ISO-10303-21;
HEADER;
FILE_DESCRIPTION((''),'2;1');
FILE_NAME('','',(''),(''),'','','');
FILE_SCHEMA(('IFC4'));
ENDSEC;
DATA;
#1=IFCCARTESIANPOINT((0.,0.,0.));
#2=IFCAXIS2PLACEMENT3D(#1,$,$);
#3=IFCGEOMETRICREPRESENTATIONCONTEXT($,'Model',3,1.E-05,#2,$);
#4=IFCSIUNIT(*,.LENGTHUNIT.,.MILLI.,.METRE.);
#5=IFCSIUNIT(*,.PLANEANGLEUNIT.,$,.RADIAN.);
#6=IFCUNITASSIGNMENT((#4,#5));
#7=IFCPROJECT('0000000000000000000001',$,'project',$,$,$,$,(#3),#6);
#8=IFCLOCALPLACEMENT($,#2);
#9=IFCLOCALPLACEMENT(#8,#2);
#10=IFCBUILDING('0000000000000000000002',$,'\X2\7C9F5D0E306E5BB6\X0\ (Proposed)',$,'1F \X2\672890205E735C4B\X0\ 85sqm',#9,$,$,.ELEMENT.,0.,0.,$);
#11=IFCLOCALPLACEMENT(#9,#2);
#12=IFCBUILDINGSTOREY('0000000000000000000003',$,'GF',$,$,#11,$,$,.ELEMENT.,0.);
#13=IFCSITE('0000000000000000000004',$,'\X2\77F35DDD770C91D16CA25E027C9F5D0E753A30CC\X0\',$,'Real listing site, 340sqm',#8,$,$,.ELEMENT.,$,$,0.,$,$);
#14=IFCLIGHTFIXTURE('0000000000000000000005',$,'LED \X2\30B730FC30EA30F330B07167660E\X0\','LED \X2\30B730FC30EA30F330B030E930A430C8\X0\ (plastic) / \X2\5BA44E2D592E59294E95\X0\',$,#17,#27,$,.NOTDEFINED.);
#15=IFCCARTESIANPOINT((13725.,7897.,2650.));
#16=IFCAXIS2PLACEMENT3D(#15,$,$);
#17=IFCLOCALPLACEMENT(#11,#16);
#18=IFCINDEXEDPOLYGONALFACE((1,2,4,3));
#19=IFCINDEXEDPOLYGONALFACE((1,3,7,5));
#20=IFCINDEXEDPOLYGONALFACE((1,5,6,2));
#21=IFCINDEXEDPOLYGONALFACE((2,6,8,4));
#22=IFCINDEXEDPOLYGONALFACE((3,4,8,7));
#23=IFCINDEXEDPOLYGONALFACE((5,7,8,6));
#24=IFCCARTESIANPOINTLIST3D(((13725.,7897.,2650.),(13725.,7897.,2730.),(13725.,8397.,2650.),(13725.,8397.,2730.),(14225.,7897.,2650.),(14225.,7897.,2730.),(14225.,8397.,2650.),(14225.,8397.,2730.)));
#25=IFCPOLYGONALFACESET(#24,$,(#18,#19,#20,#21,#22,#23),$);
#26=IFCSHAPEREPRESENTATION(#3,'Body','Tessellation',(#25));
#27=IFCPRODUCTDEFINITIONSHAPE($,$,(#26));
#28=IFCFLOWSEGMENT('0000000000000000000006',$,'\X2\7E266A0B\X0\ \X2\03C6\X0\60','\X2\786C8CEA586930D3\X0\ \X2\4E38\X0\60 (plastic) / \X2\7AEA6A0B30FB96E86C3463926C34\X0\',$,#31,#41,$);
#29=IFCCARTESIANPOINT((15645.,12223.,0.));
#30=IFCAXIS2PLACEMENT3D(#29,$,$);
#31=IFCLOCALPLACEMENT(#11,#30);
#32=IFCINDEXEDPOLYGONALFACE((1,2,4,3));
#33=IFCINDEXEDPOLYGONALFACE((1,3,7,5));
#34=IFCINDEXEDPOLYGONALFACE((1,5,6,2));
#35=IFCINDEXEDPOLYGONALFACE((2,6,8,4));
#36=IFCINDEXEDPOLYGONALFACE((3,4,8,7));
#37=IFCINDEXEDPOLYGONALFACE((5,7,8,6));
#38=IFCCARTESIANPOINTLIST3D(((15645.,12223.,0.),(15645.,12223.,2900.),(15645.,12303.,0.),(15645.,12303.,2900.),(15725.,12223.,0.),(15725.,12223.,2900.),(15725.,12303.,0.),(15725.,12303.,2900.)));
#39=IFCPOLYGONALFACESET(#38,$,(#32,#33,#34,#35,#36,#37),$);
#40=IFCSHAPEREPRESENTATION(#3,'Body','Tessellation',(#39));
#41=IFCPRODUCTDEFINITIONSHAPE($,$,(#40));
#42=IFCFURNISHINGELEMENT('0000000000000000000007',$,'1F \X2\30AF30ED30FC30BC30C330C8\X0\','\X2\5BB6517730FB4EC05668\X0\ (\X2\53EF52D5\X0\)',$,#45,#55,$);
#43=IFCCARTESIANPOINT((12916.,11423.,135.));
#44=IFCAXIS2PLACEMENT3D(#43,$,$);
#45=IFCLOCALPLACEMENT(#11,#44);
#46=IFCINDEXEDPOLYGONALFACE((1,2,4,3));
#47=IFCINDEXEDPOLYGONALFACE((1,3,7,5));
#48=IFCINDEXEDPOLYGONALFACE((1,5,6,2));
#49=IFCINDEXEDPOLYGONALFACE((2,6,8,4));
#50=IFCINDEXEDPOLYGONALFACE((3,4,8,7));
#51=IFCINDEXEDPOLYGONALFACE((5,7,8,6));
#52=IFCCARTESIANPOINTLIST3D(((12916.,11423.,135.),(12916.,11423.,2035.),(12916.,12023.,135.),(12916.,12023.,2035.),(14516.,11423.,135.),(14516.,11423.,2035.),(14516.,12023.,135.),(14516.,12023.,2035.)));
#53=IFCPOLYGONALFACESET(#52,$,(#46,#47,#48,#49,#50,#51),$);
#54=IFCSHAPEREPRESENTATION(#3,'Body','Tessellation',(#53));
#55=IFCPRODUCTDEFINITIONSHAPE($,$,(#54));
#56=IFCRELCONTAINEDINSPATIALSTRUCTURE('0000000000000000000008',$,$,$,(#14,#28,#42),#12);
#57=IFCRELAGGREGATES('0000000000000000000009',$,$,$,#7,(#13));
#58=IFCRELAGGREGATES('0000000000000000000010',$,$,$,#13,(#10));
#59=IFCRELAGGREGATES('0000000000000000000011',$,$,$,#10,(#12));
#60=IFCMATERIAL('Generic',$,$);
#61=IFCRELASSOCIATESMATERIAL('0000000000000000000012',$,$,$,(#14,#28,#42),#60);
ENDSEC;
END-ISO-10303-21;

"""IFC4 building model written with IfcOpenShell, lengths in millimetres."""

from ifc_helpers import new_model, si_unit, frame, frame_2d, origin, place, context, project, spatial, rectangle, extrude, material, element, save


model = new_model("IFC4")

# Units and contexts
model_context = context("Model", 3, precision=1e-05, world=origin())
ifc_project = project(units=[si_unit("LENGTHUNIT", "METRE", prefix="MILLI"), si_unit("PLANEANGLEUNIT", "RADIAN")], contexts=[model_context])

# Site, building, storey
site_placement = place(None, origin())
site = spatial("IfcSite", under=ifc_project, at=site_placement, Name="石川県金沢市粟崎町ヌ", ObjectType="Real listing site, 340sqm", CompositionType="ELEMENT", RefElevation=0.0)
building_placement = place(site_placement, origin())
building = spatial("IfcBuilding", under=site, at=building_placement, Name="粟崎の家 (Proposed)", ObjectType="1F 木造平屋 85sqm", CompositionType="ELEMENT", ElevationOfRefHeight=0.0, ElevationOfTerrain=0.0)
storey_placement = place(building_placement, origin())
storey = spatial("IfcBuildingStorey", under=building, at=storey_placement, Name="GF", CompositionType="ELEMENT", Elevation=0.0)

# Shared definitions
ifc_material_1 = material(Name="Generic")

# Light fixture
light_fixture_1_placement = place(storey_placement, frame((13725.0, 7897.0, 2650.0)))
element("IfcLightFixture", 1, at=light_fixture_1_placement, inside=storey, material=ifc_material_1, Name="LED シーリング照明", Description="LED シーリングライト (plastic) / 室中央天井", PredefinedType="NOTDEFINED", context=model_context, shape_type="SweptSolid", body=[
    extrude(rectangle(XDim=500.0, YDim=500.0, at=frame_2d((250.0, 250.0))), frame((13725.0, 7897.0, 2650.0)), (0.0, 0.0, 1.0), 80.0),
])

# Flow segment
flow_segment_placement = place(storey_placement, frame((15645.0, 12223.0, 0.0)))
element("IfcFlowSegment", 2, at=flow_segment_placement, inside=storey, material=ifc_material_1, Name="縦樋 φ60", Description="硬質塩ビ 丸60 (plastic) / 竪樋・雨水排水", context=model_context, shape_type="SweptSolid", body=[
    extrude(rectangle(XDim=80.0, YDim=80.0, at=frame_2d((40.0, 40.0))), frame((15645.0, 12223.0, 0.0)), (0.0, 0.0, 1.0), 2900.0),
])

# Furnishing element
furnishing_placement = place(storey_placement, frame((12916.0, 11423.0, 135.0)))
element("IfcFurnishingElement", 3, at=furnishing_placement, inside=storey, material=ifc_material_1, Name="1F クローゼット", Description="家具・什器 (可動)", context=model_context, shape_type="SweptSolid", body=[
    extrude(rectangle(XDim=1600.0, YDim=600.0, at=frame_2d((800.0, 300.0))), frame((12916.0, 11423.0, 135.0)), (0.0, 0.0, 1.0), 1900.0),
])

save(model, "model.ifc")
